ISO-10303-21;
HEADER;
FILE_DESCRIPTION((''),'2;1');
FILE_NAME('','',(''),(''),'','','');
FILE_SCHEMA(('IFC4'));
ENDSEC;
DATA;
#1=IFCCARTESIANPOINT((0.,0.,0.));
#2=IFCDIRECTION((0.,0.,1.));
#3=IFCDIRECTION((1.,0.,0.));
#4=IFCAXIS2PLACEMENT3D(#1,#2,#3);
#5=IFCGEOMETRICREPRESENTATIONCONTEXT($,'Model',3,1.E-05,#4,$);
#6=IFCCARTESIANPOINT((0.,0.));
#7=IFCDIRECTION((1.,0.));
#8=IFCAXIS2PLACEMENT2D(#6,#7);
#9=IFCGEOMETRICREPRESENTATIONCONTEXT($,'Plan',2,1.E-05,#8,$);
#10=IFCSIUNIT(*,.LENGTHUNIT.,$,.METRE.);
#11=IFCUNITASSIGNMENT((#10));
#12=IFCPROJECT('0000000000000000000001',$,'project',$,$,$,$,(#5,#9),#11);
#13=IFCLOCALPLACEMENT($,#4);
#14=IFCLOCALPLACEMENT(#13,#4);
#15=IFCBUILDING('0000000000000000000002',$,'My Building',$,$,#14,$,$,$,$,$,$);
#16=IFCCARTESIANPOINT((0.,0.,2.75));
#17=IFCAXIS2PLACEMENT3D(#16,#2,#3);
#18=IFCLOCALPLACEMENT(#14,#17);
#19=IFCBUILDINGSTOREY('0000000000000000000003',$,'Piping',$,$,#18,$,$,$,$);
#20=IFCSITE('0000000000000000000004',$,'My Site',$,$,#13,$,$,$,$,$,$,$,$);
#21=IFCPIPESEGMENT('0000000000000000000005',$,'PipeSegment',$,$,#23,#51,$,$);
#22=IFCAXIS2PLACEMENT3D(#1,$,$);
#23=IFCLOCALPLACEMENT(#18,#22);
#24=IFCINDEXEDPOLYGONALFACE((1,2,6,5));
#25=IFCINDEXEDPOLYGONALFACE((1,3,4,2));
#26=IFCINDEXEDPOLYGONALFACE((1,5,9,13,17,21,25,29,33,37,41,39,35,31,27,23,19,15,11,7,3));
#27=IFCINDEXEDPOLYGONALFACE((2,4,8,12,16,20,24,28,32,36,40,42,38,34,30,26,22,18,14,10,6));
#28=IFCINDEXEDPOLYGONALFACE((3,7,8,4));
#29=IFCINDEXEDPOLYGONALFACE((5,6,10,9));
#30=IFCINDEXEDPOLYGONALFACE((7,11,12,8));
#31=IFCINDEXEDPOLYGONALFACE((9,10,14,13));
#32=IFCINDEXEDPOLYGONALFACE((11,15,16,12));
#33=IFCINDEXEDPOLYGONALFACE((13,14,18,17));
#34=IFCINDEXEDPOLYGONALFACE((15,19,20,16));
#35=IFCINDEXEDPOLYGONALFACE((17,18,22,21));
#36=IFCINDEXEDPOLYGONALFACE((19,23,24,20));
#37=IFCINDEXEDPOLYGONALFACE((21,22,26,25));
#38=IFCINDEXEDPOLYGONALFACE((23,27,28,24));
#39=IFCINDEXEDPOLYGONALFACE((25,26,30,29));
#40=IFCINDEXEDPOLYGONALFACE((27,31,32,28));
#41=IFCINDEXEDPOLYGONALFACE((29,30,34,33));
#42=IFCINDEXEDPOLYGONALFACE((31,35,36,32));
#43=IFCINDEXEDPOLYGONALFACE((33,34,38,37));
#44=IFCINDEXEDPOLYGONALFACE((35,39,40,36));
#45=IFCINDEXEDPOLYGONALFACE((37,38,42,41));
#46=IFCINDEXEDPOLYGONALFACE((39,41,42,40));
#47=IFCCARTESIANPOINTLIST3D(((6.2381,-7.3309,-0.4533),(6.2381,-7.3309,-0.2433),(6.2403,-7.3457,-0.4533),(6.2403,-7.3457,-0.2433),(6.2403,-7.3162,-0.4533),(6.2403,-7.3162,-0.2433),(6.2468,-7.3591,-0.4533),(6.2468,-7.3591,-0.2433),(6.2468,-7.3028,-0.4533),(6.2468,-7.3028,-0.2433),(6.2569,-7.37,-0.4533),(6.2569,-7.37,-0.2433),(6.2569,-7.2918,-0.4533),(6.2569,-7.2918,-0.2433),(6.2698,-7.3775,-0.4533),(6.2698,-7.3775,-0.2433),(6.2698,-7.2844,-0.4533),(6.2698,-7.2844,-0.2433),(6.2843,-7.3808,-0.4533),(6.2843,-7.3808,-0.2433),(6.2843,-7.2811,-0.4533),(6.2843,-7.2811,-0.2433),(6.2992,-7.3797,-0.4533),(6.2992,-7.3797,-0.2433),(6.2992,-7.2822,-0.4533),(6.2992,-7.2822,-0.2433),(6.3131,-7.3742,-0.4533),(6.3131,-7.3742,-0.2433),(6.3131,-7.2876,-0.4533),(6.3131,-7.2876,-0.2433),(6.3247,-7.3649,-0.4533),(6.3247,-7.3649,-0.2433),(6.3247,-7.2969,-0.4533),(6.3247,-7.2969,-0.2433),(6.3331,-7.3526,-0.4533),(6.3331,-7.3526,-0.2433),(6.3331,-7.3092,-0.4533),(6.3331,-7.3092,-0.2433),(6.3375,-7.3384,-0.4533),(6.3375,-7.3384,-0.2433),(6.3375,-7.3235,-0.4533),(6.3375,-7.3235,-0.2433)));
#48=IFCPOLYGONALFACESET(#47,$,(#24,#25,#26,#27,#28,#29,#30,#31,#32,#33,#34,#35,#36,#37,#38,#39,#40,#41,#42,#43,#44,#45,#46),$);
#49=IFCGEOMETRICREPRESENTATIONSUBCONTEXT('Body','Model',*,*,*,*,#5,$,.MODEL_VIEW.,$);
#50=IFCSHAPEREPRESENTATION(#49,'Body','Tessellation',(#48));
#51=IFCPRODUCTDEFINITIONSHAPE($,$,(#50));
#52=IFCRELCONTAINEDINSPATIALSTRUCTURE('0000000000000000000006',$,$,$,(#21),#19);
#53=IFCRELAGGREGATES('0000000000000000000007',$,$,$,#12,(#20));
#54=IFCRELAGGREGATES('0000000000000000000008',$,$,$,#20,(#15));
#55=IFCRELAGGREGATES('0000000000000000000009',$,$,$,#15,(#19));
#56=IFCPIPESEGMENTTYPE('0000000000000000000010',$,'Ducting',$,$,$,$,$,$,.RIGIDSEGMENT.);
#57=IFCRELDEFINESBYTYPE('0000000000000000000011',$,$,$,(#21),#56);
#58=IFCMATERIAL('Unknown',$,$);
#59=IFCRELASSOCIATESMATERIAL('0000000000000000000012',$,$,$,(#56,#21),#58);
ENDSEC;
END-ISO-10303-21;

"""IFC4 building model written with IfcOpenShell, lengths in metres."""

from ifc_helpers import new_model, si_unit, frame, origin_with_axes, origin_2d_with_axis, place, context, subcontext, project, spatial, circle, extrude, material, material_profile, profile_set, profile_usage, type_object, element, save


model = new_model("IFC4")

# Units and contexts
model_context = context("Model", 3, precision=1e-05, world=origin_with_axes())
plan_context = context("Plan", 2, precision=1e-05, world=origin_2d_with_axis())
body_context = subcontext(model_context, "Body", "Model", "MODEL_VIEW")
ifc_project = project(units=[si_unit("LENGTHUNIT", "METRE")], contexts=[model_context, plan_context])

# Site, building, storey
site_placement = place(None, origin_with_axes())
site = spatial("IfcSite", under=ifc_project, at=site_placement, Name="My Site")
building_placement = place(site_placement, origin_with_axes())
building = spatial("IfcBuilding", under=site, at=building_placement, Name="My Building")
storey_placement = place(building_placement, frame((0.0, 0.0, 2.75), z_axis=(0.0, 0.0, 1.0), x_axis=(1.0, 0.0, 0.0)))
storey = spatial("IfcBuildingStorey", under=building, at=storey_placement, Name="Piping")

# Pipe segment
ifc_material = material(Name="Unknown")
ifc_material_profile = material_profile(ifc_material, circle(Radius=0.05))
ifc_profile_set = profile_set([ifc_material_profile])
pipe_segment_type = type_object("IfcPipeSegmentType", Name="Ducting", PredefinedType="RIGIDSEGMENT", material=ifc_profile_set)
ifc_profile_usage_1 = profile_usage(ifc_profile_set, cardinal=4)
pipe_segment_1_placement = place(storey_placement, frame((6.2381, -7.3309, -0.2433), z_axis=(0.0, 0.0, -1.0), x_axis=(-1.0, 0.0, 0.0)))
element("IfcPipeSegment", 1, at=pipe_segment_1_placement, inside=storey, type_object=pipe_segment_type, material=ifc_profile_usage_1, Name="PipeSegment", context=body_context, shape_type="SweptSolid", body=[
    extrude(circle(Radius=0.05), frame((-0.05, 0.0, 0.0), z_axis=(0.0, 0.0, 1.0), x_axis=(1.0, 0.0, 0.0)), (0.0, 0.0, 1.0), 0.21),
])

save(model, "model.ifc")
